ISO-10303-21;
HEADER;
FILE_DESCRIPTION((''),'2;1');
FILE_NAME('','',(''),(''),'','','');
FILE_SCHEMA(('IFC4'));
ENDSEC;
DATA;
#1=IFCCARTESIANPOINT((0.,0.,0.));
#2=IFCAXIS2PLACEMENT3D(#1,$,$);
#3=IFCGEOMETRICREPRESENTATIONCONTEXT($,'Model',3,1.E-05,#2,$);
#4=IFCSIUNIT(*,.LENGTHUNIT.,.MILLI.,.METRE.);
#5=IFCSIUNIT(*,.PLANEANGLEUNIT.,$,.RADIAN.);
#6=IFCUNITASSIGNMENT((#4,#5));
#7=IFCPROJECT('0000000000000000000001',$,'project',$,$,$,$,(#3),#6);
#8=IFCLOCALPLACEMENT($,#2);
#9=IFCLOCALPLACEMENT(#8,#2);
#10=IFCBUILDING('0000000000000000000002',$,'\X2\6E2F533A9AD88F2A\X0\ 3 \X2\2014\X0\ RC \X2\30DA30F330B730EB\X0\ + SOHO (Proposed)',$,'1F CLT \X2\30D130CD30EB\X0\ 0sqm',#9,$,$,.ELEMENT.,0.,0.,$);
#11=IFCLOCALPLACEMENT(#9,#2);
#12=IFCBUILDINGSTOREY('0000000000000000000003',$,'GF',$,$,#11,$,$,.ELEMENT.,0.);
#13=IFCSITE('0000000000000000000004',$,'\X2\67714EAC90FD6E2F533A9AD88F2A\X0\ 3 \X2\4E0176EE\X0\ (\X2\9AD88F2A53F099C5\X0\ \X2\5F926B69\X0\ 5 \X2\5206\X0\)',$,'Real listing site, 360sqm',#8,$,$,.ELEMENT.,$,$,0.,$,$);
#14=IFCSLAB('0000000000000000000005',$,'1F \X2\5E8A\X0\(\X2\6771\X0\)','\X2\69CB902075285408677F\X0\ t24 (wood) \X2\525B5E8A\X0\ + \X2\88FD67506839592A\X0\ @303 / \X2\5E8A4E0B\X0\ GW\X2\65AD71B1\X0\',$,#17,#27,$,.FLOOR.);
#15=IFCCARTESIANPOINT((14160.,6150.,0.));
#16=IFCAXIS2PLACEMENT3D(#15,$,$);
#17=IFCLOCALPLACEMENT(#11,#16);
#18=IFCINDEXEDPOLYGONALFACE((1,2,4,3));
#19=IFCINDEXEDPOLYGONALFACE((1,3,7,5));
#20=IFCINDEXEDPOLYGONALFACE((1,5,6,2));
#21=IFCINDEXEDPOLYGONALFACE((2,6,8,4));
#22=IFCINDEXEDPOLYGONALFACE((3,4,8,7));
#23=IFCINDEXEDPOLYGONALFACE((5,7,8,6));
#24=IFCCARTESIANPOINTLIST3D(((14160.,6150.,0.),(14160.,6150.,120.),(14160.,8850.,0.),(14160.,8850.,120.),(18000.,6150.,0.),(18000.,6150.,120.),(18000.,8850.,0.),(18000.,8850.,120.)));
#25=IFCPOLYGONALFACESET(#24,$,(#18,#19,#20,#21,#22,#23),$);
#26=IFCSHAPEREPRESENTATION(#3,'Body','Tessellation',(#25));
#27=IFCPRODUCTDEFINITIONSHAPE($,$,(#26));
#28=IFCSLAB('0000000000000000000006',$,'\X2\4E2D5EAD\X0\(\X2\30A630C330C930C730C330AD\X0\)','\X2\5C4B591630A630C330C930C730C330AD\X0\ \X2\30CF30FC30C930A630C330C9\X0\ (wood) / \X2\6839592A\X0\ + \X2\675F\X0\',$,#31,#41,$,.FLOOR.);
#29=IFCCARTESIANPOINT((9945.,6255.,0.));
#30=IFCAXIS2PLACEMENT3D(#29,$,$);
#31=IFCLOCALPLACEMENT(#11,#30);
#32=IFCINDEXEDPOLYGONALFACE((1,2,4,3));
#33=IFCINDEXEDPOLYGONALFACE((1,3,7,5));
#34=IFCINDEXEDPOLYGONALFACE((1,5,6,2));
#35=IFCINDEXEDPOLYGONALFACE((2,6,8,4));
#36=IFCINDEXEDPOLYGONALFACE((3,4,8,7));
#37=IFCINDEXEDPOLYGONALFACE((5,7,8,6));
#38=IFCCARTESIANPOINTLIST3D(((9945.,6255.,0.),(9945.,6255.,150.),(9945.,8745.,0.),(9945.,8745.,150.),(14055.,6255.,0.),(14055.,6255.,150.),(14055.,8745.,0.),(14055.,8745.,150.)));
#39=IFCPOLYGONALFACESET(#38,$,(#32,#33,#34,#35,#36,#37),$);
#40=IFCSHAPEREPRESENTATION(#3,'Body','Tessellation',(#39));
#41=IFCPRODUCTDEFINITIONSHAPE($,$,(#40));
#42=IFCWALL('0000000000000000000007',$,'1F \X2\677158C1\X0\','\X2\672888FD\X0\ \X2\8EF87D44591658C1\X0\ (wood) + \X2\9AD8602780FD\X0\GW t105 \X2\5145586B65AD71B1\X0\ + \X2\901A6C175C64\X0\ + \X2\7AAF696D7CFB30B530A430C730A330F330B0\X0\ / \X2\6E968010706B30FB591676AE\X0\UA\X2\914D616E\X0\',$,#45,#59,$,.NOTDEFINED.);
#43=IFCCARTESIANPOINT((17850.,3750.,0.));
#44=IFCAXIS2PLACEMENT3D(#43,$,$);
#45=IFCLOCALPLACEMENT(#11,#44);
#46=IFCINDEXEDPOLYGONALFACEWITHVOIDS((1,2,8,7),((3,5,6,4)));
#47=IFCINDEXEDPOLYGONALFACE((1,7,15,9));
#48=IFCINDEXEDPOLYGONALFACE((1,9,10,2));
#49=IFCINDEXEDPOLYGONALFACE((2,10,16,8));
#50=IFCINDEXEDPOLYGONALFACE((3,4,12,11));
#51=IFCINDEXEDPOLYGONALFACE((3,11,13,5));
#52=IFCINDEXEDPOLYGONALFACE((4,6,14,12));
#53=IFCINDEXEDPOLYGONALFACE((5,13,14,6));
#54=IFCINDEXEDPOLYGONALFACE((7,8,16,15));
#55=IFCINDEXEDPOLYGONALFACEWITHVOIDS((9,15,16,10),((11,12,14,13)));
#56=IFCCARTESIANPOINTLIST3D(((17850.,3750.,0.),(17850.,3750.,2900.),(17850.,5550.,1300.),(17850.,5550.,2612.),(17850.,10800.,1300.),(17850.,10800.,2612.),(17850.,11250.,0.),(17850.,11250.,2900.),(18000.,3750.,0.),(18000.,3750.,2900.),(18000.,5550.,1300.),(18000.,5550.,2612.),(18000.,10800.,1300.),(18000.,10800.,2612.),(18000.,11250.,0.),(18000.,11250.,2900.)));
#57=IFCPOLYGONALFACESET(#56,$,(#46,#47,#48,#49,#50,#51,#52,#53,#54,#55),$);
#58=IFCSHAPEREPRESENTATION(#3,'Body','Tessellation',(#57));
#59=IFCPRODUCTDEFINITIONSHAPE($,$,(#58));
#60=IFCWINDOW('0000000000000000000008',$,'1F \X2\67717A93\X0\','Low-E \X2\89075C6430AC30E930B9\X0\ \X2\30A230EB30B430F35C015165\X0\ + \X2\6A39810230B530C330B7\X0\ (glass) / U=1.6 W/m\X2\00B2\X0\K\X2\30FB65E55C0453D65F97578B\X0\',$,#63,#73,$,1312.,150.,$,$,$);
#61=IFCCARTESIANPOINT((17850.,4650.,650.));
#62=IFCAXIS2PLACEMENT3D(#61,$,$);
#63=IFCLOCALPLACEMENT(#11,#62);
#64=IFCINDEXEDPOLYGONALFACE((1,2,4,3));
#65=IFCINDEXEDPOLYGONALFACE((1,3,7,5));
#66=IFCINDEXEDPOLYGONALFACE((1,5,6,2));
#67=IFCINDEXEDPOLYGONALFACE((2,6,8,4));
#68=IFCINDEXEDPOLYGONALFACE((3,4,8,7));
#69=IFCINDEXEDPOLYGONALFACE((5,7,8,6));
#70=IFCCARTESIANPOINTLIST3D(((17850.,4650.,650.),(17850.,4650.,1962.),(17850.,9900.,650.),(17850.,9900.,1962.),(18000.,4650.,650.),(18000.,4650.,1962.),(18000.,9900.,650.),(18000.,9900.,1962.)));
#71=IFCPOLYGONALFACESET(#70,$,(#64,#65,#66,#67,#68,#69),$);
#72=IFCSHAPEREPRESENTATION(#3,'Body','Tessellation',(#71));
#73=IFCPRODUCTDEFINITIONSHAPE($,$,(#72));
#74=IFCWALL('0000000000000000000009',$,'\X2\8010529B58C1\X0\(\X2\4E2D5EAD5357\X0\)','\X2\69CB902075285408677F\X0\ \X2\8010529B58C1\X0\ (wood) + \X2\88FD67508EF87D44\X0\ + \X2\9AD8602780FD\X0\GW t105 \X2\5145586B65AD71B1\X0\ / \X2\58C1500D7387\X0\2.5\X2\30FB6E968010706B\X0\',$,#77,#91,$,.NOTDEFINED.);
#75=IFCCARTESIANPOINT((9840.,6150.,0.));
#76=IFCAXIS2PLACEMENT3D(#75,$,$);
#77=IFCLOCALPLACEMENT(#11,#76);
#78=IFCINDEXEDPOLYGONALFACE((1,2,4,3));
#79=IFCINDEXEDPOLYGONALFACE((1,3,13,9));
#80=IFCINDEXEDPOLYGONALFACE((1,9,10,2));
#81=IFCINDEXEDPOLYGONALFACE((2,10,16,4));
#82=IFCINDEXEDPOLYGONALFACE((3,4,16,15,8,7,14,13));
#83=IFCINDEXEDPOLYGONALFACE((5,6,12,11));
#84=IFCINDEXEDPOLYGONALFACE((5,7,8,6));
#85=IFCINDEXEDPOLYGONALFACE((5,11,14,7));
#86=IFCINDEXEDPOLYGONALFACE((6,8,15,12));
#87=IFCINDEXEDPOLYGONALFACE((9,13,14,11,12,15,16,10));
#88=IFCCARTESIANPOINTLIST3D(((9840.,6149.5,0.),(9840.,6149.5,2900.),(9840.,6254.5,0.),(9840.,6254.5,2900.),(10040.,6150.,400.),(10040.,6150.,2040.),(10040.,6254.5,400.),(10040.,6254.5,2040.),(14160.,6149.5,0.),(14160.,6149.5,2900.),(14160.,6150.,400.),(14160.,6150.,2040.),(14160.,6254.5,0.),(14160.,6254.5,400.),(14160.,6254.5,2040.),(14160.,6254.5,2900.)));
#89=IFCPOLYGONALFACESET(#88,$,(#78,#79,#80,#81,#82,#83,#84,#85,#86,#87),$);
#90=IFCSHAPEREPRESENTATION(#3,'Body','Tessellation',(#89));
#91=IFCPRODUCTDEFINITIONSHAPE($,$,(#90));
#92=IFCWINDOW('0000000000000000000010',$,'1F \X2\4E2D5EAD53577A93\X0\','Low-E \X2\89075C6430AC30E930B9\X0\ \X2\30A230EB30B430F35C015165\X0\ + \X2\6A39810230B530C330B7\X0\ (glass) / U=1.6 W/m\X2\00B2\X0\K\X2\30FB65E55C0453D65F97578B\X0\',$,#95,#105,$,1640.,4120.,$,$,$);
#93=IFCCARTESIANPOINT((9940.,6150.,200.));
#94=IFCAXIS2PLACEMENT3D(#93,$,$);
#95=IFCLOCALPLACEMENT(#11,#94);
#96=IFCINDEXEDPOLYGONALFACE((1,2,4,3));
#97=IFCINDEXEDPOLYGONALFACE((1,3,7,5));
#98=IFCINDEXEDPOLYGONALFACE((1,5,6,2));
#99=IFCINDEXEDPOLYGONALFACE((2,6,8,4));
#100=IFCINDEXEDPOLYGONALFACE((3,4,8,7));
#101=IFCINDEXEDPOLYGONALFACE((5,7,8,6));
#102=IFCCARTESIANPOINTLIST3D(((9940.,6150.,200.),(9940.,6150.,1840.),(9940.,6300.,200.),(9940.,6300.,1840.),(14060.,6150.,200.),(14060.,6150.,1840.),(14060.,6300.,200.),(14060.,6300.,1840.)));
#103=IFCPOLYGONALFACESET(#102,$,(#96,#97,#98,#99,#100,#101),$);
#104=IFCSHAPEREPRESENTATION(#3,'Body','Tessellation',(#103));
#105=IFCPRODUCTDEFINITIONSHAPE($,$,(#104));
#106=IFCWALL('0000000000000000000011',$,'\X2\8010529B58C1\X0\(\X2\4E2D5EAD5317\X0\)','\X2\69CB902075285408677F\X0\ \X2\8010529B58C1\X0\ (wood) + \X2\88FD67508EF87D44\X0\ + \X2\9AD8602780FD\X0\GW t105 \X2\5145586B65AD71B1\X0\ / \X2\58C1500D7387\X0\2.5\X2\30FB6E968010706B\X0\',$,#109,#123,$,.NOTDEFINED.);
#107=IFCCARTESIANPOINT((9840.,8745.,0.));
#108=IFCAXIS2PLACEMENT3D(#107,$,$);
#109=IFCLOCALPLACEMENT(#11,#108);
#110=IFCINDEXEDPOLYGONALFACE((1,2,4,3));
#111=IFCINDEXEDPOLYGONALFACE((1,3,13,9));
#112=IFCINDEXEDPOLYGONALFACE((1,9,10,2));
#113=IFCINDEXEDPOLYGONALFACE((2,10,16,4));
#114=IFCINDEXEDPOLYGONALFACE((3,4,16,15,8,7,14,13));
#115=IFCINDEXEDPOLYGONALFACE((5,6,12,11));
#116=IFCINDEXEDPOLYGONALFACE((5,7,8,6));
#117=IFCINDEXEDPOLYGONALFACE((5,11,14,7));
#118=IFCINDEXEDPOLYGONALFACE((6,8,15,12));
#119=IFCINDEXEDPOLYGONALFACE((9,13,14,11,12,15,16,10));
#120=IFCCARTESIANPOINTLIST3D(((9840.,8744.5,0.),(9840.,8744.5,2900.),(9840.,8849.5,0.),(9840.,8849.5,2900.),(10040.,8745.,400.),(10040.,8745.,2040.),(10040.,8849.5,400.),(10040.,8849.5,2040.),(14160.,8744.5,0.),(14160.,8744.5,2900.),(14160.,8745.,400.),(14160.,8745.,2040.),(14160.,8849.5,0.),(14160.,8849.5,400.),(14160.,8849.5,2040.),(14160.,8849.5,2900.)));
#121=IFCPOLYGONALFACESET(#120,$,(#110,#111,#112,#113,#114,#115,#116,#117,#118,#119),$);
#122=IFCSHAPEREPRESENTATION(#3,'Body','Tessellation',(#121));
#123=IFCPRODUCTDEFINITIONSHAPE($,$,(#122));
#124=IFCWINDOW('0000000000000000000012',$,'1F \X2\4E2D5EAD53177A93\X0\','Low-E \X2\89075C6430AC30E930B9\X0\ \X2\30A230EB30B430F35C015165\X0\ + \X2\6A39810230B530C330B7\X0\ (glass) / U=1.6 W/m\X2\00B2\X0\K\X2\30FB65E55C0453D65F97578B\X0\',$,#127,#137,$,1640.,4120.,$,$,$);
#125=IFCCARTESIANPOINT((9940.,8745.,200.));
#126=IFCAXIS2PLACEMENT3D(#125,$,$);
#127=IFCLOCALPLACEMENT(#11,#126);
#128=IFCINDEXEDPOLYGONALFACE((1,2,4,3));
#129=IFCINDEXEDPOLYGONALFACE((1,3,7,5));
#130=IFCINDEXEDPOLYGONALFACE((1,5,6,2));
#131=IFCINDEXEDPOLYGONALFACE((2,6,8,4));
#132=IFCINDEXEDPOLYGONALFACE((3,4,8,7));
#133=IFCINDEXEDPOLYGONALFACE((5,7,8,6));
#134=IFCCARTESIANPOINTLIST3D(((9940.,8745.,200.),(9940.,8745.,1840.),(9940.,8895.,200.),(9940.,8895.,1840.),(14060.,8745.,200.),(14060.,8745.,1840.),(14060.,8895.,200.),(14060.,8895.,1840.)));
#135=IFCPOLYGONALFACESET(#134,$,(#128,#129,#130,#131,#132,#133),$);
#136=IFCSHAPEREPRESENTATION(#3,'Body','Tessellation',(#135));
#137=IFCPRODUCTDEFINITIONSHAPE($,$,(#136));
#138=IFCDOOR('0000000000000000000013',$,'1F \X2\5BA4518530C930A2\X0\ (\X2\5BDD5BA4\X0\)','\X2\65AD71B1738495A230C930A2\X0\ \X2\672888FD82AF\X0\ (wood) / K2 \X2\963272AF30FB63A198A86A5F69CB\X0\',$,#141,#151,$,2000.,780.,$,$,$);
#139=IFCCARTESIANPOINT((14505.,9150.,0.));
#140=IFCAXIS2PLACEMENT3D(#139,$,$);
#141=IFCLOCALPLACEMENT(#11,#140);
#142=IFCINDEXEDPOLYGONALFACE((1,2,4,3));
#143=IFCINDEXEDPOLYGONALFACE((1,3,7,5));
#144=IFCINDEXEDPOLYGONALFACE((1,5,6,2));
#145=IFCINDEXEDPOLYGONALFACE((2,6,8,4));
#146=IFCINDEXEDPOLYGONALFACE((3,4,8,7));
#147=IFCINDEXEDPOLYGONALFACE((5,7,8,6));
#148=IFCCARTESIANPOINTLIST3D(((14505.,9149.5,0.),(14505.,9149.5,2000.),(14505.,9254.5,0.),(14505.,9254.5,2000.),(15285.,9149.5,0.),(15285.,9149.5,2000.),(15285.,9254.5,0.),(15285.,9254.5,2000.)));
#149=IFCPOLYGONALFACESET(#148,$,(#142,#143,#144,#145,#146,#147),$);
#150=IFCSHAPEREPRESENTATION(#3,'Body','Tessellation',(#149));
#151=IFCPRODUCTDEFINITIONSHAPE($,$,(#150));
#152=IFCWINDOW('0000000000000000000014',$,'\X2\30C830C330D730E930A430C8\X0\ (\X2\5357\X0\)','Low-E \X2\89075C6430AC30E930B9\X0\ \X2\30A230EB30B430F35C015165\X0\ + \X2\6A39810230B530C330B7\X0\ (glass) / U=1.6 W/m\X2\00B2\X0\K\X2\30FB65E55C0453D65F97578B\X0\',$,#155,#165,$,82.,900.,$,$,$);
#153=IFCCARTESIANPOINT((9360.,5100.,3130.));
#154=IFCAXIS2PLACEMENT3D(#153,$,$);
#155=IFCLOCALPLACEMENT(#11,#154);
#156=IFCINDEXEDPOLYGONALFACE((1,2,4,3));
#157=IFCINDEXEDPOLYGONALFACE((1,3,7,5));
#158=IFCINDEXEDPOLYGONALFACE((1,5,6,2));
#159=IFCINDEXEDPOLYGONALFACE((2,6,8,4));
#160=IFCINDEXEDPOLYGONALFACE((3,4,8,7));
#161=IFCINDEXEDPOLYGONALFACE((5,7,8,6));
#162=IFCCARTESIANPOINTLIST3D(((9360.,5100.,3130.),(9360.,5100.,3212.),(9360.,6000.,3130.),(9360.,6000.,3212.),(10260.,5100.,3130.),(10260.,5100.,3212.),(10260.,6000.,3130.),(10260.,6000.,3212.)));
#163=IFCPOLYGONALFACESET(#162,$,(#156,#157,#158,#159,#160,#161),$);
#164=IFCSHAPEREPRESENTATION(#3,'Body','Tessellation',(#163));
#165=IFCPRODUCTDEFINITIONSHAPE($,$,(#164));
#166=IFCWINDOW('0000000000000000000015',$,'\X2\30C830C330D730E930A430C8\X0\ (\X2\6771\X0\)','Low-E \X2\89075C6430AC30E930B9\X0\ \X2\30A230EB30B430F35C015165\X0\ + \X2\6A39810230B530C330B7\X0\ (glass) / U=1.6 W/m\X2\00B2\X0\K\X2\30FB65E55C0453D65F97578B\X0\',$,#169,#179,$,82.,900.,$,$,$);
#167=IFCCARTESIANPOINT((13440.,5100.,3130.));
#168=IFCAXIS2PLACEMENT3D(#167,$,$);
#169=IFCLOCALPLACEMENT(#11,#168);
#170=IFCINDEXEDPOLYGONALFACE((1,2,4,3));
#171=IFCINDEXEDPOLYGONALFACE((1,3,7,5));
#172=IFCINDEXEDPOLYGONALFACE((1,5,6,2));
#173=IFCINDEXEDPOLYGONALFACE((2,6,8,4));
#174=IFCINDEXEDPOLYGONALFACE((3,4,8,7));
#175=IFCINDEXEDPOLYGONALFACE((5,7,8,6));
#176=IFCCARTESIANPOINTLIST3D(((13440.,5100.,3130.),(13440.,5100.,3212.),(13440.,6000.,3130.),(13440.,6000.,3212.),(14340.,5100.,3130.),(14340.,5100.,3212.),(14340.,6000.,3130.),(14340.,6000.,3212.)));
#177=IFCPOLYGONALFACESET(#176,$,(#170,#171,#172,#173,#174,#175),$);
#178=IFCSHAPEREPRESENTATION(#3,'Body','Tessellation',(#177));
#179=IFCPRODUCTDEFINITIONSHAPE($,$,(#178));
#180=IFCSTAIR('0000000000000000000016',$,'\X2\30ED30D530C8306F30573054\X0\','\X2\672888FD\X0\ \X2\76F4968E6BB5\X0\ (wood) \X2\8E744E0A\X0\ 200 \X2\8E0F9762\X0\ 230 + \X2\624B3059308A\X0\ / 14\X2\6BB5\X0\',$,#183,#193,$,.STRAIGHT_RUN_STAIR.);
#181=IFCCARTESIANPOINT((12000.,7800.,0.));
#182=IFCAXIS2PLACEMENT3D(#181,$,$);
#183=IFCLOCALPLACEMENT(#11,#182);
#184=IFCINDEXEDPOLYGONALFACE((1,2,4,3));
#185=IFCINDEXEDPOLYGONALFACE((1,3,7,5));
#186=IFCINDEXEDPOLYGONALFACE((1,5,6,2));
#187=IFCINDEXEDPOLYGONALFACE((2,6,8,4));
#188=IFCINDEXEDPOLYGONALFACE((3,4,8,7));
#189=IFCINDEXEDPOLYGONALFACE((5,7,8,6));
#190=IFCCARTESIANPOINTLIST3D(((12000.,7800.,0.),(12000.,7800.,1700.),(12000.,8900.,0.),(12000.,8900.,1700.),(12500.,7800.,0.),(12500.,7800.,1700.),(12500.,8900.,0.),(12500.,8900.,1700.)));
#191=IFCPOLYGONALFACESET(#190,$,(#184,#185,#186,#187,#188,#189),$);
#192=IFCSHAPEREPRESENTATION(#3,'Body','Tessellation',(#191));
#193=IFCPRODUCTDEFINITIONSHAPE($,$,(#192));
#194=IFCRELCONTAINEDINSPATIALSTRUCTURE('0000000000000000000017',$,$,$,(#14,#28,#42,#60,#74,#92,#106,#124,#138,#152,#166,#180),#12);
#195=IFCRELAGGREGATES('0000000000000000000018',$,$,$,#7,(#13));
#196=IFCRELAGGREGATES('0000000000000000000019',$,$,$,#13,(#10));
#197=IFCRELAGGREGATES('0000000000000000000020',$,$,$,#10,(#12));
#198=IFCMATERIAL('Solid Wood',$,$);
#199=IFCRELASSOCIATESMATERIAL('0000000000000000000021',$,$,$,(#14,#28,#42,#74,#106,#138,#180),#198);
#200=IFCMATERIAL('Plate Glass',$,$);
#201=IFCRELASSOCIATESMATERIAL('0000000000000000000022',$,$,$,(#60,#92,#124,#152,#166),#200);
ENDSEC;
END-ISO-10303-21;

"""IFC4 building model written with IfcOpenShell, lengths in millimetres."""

from ifc_helpers import new_model, si_unit, frame, frame_2d, origin, place, context, project, spatial, rectangle, extrude, material, element, fill, save


model = new_model("IFC4")

# Units and contexts
model_context = context("Model", 3, precision=1e-05, world=origin())
ifc_project = project(units=[si_unit("LENGTHUNIT", "METRE", prefix="MILLI"), si_unit("PLANEANGLEUNIT", "RADIAN")], contexts=[model_context])

# Site, building, storey
site_placement = place(None, origin())
site = spatial("IfcSite", under=ifc_project, at=site_placement, Name="東京都港区高輪 3 丁目 (高輪台駅 徒歩 5 分)", ObjectType="Real listing site, 360sqm", CompositionType="ELEMENT", RefElevation=0.0)
building_placement = place(site_placement, origin())
building = spatial("IfcBuilding", under=site, at=building_placement, Name="港区高輪 3 — RC ペンシル + SOHO (Proposed)", ObjectType="1F CLT パネル 0sqm", CompositionType="ELEMENT", ElevationOfRefHeight=0.0, ElevationOfTerrain=0.0)
storey_placement = place(building_placement, origin())
storey = spatial("IfcBuildingStorey", under=building, at=storey_placement, Name="GF", CompositionType="ELEMENT", Elevation=0.0)

# Slabs
ifc_material_1 = material(Name="Solid Wood")
slab_1_placement = place(storey_placement, frame((14160.0, 6150.0, 0.0)))
element("IfcSlab", 1, at=slab_1_placement, inside=storey, material=ifc_material_1, Name="1F 床(東)", Description="構造用合板 t24 (wood) 剛床 + 製材根太 @303 / 床下 GW断熱", PredefinedType="FLOOR", context=model_context, shape_type="SweptSolid", body=[
    extrude(rectangle(XDim=3840.0, YDim=2700.0, at=frame_2d((1920.0, 1350.0))), frame((14160.0, 6150.0, 0.0)), (0.0, 0.0, 1.0), 120.0),
])
slab_2_placement = place(storey_placement, frame((9945.0, 6255.0, 0.0)))
element("IfcSlab", 2, at=slab_2_placement, inside=storey, material=ifc_material_1, Name="中庭(ウッドデッキ)", Description="屋外ウッドデッキ ハードウッド (wood) / 根太 + 束", PredefinedType="FLOOR", context=model_context, shape_type="SweptSolid", body=[
    extrude(rectangle(XDim=4110.0, YDim=2490.0, at=frame_2d((2055.0, 1245.0))), frame((9945.0, 6255.0, 0.0)), (0.0, 0.0, 1.0), 150.0),
])

# Walls, openings, windows
wall_1_placement = place(storey_placement, frame((17850.0, 3750.0, 0.0)))
wall_1 = element("IfcWall", 3, at=wall_1_placement, inside=storey, material=ifc_material_1, Name="1F 東壁", Description="木製 軸組外壁 (wood) + 高性能GW t105 充填断熱 + 通気層 + 窯業系サイディング / 準耐火・外皮UA配慮", PredefinedType="NOTDEFINED", context=model_context, shape_type="SweptSolid", body=[
    extrude(rectangle(XDim=150.0, YDim=7500.0, at=frame_2d((75.0, 3750.0))), frame((17850.0, 3750.0, 0.0)), (0.0, 0.0, 1.0), 2900.0),
])
opening_1_placement = place(storey_placement, frame((17850.0, 4650.0, 650.0)))
opening_1 = element("IfcOpeningElement", 4, at=opening_1_placement, cuts=wall_1, PredefinedType="NOTDEFINED", context=model_context, shape_type="SweptSolid", body=[
    extrude(rectangle(XDim=150.0, YDim=5250.0, at=frame_2d((75.0, 2625.0))), frame((17850.0, 4650.0, 650.0)), (0.0, 0.0, 1.0), 1312.0),
])
ifc_material_2 = material(Name="Plate Glass")
window_1_placement = place(storey_placement, frame((17850.0, 4650.0, 650.0)))
window_1 = element("IfcWindow", 5, at=window_1_placement, inside=storey, material=ifc_material_2, Name="1F 東窓", Description="Low-E 複層ガラス アルゴン封入 + 樹脂サッシ (glass) / U=1.6 W/m²K・日射取得型", OverallHeight=1312.0, OverallWidth=150.0, context=model_context, shape_type="SweptSolid", body=[
    extrude(rectangle(XDim=150.0, YDim=5250.0, at=frame_2d((75.0, 2625.0))), frame((17850.0, 4650.0, 650.0)), (0.0, 0.0, 1.0), 1312.0),
])
fill(opening_1, window_1)
wall_2_placement = place(storey_placement, frame((9840.0, 6150.0, 0.0)))
wall_2 = element("IfcWall", 6, at=wall_2_placement, inside=storey, material=ifc_material_1, Name="耐力壁(中庭南)", Description="構造用合板 耐力壁 (wood) + 製材軸組 + 高性能GW t105 充填断熱 / 壁倍率2.5・準耐火", PredefinedType="NOTDEFINED", context=model_context, shape_type="SweptSolid", body=[
    extrude(rectangle(XDim=4320.0, YDim=105.0, at=frame_2d((2160.0, 52.0))), frame((9840.0, 6150.0, 0.0)), (0.0, 0.0, 1.0), 2900.0),
])
opening_2_placement = place(storey_placement, frame((9940.0, 6150.0, 200.0)))
opening_2 = element("IfcOpeningElement", 7, at=opening_2_placement, cuts=wall_2, PredefinedType="NOTDEFINED", context=model_context, shape_type="SweptSolid", body=[
    extrude(rectangle(XDim=4120.0, YDim=150.0, at=frame_2d((2060.0, 75.0))), frame((9940.0, 6150.0, 200.0)), (0.0, 0.0, 1.0), 1640.0),
])
window_2_placement = place(storey_placement, frame((9940.0, 6150.0, 200.0)))
window_2 = element("IfcWindow", 8, at=window_2_placement, inside=storey, material=ifc_material_2, Name="1F 中庭南窓", Description="Low-E 複層ガラス アルゴン封入 + 樹脂サッシ (glass) / U=1.6 W/m²K・日射取得型", OverallHeight=1640.0, OverallWidth=4120.0, context=model_context, shape_type="SweptSolid", body=[
    extrude(rectangle(XDim=4120.0, YDim=150.0, at=frame_2d((2060.0, 75.0))), frame((9940.0, 6150.0, 200.0)), (0.0, 0.0, 1.0), 1640.0),
])
fill(opening_2, window_2)
wall_3_placement = place(storey_placement, frame((9840.0, 8745.0, 0.0)))
wall_3 = element("IfcWall", 9, at=wall_3_placement, inside=storey, material=ifc_material_1, Name="耐力壁(中庭北)", Description="構造用合板 耐力壁 (wood) + 製材軸組 + 高性能GW t105 充填断熱 / 壁倍率2.5・準耐火", PredefinedType="NOTDEFINED", context=model_context, shape_type="SweptSolid", body=[
    extrude(rectangle(XDim=4320.0, YDim=105.0, at=frame_2d((2160.0, 52.0))), frame((9840.0, 8745.0, 0.0)), (0.0, 0.0, 1.0), 2900.0),
])
opening_3_placement = place(storey_placement, frame((9940.0, 8745.0, 200.0)))
opening_3 = element("IfcOpeningElement", 10, at=opening_3_placement, cuts=wall_3, PredefinedType="NOTDEFINED", context=model_context, shape_type="SweptSolid", body=[
    extrude(rectangle(XDim=4120.0, YDim=150.0, at=frame_2d((2060.0, 75.0))), frame((9940.0, 8745.0, 200.0)), (0.0, 0.0, 1.0), 1640.0),
])
window_3_placement = place(storey_placement, frame((9940.0, 8745.0, 200.0)))
window_3 = element("IfcWindow", 11, at=window_3_placement, inside=storey, material=ifc_material_2, Name="1F 中庭北窓", Description="Low-E 複層ガラス アルゴン封入 + 樹脂サッシ (glass) / U=1.6 W/m²K・日射取得型", OverallHeight=1640.0, OverallWidth=4120.0, context=model_context, shape_type="SweptSolid", body=[
    extrude(rectangle(XDim=4120.0, YDim=150.0, at=frame_2d((2060.0, 75.0))), frame((9940.0, 8745.0, 200.0)), (0.0, 0.0, 1.0), 1640.0),
])
fill(opening_3, window_3)

# Door
door_placement = place(storey_placement, frame((14505.0, 9150.0, 0.0)))
element("IfcDoor", 12, at=door_placement, inside=storey, material=ifc_material_1, Name="1F 室内ドア (寝室)", Description="断熱玄関ドア 木製芯 (wood) / K2 防犯・採風機構", OverallHeight=2000.0, OverallWidth=780.0, context=model_context, shape_type="SweptSolid", body=[
    extrude(rectangle(XDim=780.0, YDim=105.0, at=frame_2d((390.0, 52.0))), frame((14505.0, 9150.0, 0.0)), (0.0, 0.0, 1.0), 2000.0),
])

# Windows
window_4_placement = place(storey_placement, frame((9360.0, 5100.0, 3130.0)))
element("IfcWindow", 13, at=window_4_placement, inside=storey, material=ifc_material_2, Name="トップライト (南)", Description="Low-E 複層ガラス アルゴン封入 + 樹脂サッシ (glass) / U=1.6 W/m²K・日射取得型", OverallHeight=82.0, OverallWidth=900.0, context=model_context, shape_type="SweptSolid", body=[
    extrude(rectangle(XDim=900.0, YDim=900.0, at=frame_2d((450.0, 450.0))), frame((9360.0, 5100.0, 3130.0)), (0.0, 0.0, 1.0), 82.0),
])
window_5_placement = place(storey_placement, frame((13440.0, 5100.0, 3130.0)))
element("IfcWindow", 14, at=window_5_placement, inside=storey, material=ifc_material_2, Name="トップライト (東)", Description="Low-E 複層ガラス アルゴン封入 + 樹脂サッシ (glass) / U=1.6 W/m²K・日射取得型", OverallHeight=82.0, OverallWidth=900.0, context=model_context, shape_type="SweptSolid", body=[
    extrude(rectangle(XDim=900.0, YDim=900.0, at=frame_2d((450.0, 450.0))), frame((13440.0, 5100.0, 3130.0)), (0.0, 0.0, 1.0), 82.0),
])

# Stair
stair_placement = place(storey_placement, frame((12000.0, 7800.0, 0.0)))
element("IfcStair", 15, at=stair_placement, inside=storey, material=ifc_material_1, Name="ロフトはしご", Description="木製 直階段 (wood) 蹴上 200 踏面 230 + 手すり / 14段", PredefinedType="STRAIGHT_RUN_STAIR", context=model_context, shape_type="SweptSolid", body=[
    extrude(rectangle(XDim=500.0, YDim=1100.0, at=frame_2d((250.0, 550.0))), frame((12000.0, 7800.0, 0.0)), (0.0, 0.0, 1.0), 1700.0),
])

save(model, "model.ifc")
